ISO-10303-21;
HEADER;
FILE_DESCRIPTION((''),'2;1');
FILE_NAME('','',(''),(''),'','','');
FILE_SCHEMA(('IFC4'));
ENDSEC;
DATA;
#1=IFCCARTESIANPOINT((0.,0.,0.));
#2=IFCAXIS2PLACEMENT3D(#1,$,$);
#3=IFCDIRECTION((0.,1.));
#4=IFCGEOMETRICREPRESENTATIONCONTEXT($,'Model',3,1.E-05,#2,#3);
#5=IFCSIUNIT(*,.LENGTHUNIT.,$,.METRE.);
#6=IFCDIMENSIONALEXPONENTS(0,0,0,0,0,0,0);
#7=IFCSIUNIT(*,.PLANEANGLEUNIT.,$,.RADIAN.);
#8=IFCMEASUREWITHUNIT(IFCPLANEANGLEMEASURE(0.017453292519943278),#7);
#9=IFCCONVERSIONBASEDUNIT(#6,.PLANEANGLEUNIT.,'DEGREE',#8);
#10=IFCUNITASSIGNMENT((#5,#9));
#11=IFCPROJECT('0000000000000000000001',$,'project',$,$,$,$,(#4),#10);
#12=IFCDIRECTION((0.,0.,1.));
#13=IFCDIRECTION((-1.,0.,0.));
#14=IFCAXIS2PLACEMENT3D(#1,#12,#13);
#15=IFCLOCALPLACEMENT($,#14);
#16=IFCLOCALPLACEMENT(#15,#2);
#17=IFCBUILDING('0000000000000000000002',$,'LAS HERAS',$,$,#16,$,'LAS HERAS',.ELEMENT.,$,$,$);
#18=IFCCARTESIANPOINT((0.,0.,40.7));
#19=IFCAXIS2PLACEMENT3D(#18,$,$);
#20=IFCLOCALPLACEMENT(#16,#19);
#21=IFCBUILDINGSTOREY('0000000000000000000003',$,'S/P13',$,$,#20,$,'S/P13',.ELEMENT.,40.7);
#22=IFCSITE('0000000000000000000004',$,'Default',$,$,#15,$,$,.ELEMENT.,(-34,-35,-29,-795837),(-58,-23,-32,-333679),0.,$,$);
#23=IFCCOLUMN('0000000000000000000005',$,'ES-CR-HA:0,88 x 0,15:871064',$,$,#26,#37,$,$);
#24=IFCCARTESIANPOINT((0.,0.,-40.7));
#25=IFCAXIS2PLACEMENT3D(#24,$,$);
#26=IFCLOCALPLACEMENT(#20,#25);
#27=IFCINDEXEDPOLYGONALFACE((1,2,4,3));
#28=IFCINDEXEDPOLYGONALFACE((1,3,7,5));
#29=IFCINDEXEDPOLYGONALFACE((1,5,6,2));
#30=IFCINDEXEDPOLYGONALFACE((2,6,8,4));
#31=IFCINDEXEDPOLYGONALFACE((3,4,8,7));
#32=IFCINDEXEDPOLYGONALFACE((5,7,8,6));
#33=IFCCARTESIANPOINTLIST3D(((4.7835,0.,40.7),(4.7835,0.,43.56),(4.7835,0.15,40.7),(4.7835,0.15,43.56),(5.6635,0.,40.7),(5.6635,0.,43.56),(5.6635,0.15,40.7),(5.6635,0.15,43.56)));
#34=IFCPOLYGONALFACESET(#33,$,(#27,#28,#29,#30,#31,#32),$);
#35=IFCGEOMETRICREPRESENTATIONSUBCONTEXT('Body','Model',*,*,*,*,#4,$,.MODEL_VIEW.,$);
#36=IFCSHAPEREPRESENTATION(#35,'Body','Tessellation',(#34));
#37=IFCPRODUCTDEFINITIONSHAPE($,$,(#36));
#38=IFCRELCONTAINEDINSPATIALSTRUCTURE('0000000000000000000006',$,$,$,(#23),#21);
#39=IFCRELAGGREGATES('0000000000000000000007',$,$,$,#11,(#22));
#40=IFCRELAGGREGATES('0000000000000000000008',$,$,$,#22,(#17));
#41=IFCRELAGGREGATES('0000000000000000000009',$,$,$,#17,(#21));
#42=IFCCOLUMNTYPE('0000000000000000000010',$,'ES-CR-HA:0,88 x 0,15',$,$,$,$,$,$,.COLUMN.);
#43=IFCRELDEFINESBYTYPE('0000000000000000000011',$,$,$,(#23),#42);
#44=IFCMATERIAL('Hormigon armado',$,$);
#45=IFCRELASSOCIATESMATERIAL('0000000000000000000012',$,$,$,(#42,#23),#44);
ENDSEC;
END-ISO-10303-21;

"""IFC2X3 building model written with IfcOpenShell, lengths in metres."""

from ifc_helpers import new_model, entity, si_unit, converted_unit, direction, frame, frame_2d, origin, place, context, subcontext, project, spatial, rectangle, extrude, source, transform, mapped, material, type_object, type_shapes, element, save


model = new_model("IFC2X3")

# Units and contexts
model_context = context("Model", 3, precision=1e-05, world=origin(), true_north=direction((0.0, 1.0)))
body_context = subcontext(model_context, "Body", "Model", "MODEL_VIEW")
ifc_project = project(units=[si_unit("LENGTHUNIT", "METRE"), converted_unit("PLANEANGLEUNIT", "DEGREE", entity("IfcPlaneAngleMeasure", 0.017453292519943278), si_unit("PLANEANGLEUNIT", "RADIAN"), dimensions=[0, 0, 0, 0, 0, 0, 0])], contexts=[model_context])

# Site, building, storey
site_placement = place(None, frame((0.0, 0.0, 0.0), z_axis=(0.0, 0.0, 1.0), x_axis=(-1.0, 0.0, 0.0)))
site = spatial("IfcSite", under=ifc_project, at=site_placement, Name="Default", CompositionType="ELEMENT", RefLatitude=(-34, -35, -29, -795837), RefLongitude=(-58, -23, -32, -333679), RefElevation=0.0)
building_placement = place(site_placement, origin())
building = spatial("IfcBuilding", under=site, at=building_placement, Name="LAS HERAS", LongName="LAS HERAS", CompositionType="ELEMENT")
storey_placement = place(building_placement, frame((0.0, 0.0, 40.7)))
storey = spatial("IfcBuildingStorey", under=building, at=storey_placement, Name="S/P13", LongName="S/P13", CompositionType="ELEMENT", Elevation=40.7)

# Column
ifc_material = material(Name="Hormigon armado")
column_type_1 = type_object("IfcColumnType", Name="ES-CR-HA:0,88 x 0,15", PredefinedType="COLUMN", material=ifc_material)
shared_shape_1 = source(origin(), body_context, "Body", "SweptSolid", [
    extrude(rectangle(XDim=0.15, YDim=0.88, at=frame_2d((0.0, 0.0), x_axis=(1.0, 0.0))), frame((5.2235, 0.075, 40.7), z_axis=(0.0, 0.0, 1.0), x_axis=(0.0, 1.0, 0.0)), (0.0, 0.0, 1.0), 2.86),
])
type_shapes(column_type_1, [shared_shape_1])
column_1_placement = place(storey_placement, frame((0.0, 0.0, -40.7)))
element("IfcColumn", 1, at=column_1_placement, inside=storey, type_object=column_type_1, material=ifc_material, Name="ES-CR-HA:0,88 x 0,15:871064", context=body_context, shape_type="MappedRepresentation", body=[
    mapped(shared_shape_1, transform((0.0, 0.0, 0.0), scale=1.0)),
])

save(model, "model.ifc")
